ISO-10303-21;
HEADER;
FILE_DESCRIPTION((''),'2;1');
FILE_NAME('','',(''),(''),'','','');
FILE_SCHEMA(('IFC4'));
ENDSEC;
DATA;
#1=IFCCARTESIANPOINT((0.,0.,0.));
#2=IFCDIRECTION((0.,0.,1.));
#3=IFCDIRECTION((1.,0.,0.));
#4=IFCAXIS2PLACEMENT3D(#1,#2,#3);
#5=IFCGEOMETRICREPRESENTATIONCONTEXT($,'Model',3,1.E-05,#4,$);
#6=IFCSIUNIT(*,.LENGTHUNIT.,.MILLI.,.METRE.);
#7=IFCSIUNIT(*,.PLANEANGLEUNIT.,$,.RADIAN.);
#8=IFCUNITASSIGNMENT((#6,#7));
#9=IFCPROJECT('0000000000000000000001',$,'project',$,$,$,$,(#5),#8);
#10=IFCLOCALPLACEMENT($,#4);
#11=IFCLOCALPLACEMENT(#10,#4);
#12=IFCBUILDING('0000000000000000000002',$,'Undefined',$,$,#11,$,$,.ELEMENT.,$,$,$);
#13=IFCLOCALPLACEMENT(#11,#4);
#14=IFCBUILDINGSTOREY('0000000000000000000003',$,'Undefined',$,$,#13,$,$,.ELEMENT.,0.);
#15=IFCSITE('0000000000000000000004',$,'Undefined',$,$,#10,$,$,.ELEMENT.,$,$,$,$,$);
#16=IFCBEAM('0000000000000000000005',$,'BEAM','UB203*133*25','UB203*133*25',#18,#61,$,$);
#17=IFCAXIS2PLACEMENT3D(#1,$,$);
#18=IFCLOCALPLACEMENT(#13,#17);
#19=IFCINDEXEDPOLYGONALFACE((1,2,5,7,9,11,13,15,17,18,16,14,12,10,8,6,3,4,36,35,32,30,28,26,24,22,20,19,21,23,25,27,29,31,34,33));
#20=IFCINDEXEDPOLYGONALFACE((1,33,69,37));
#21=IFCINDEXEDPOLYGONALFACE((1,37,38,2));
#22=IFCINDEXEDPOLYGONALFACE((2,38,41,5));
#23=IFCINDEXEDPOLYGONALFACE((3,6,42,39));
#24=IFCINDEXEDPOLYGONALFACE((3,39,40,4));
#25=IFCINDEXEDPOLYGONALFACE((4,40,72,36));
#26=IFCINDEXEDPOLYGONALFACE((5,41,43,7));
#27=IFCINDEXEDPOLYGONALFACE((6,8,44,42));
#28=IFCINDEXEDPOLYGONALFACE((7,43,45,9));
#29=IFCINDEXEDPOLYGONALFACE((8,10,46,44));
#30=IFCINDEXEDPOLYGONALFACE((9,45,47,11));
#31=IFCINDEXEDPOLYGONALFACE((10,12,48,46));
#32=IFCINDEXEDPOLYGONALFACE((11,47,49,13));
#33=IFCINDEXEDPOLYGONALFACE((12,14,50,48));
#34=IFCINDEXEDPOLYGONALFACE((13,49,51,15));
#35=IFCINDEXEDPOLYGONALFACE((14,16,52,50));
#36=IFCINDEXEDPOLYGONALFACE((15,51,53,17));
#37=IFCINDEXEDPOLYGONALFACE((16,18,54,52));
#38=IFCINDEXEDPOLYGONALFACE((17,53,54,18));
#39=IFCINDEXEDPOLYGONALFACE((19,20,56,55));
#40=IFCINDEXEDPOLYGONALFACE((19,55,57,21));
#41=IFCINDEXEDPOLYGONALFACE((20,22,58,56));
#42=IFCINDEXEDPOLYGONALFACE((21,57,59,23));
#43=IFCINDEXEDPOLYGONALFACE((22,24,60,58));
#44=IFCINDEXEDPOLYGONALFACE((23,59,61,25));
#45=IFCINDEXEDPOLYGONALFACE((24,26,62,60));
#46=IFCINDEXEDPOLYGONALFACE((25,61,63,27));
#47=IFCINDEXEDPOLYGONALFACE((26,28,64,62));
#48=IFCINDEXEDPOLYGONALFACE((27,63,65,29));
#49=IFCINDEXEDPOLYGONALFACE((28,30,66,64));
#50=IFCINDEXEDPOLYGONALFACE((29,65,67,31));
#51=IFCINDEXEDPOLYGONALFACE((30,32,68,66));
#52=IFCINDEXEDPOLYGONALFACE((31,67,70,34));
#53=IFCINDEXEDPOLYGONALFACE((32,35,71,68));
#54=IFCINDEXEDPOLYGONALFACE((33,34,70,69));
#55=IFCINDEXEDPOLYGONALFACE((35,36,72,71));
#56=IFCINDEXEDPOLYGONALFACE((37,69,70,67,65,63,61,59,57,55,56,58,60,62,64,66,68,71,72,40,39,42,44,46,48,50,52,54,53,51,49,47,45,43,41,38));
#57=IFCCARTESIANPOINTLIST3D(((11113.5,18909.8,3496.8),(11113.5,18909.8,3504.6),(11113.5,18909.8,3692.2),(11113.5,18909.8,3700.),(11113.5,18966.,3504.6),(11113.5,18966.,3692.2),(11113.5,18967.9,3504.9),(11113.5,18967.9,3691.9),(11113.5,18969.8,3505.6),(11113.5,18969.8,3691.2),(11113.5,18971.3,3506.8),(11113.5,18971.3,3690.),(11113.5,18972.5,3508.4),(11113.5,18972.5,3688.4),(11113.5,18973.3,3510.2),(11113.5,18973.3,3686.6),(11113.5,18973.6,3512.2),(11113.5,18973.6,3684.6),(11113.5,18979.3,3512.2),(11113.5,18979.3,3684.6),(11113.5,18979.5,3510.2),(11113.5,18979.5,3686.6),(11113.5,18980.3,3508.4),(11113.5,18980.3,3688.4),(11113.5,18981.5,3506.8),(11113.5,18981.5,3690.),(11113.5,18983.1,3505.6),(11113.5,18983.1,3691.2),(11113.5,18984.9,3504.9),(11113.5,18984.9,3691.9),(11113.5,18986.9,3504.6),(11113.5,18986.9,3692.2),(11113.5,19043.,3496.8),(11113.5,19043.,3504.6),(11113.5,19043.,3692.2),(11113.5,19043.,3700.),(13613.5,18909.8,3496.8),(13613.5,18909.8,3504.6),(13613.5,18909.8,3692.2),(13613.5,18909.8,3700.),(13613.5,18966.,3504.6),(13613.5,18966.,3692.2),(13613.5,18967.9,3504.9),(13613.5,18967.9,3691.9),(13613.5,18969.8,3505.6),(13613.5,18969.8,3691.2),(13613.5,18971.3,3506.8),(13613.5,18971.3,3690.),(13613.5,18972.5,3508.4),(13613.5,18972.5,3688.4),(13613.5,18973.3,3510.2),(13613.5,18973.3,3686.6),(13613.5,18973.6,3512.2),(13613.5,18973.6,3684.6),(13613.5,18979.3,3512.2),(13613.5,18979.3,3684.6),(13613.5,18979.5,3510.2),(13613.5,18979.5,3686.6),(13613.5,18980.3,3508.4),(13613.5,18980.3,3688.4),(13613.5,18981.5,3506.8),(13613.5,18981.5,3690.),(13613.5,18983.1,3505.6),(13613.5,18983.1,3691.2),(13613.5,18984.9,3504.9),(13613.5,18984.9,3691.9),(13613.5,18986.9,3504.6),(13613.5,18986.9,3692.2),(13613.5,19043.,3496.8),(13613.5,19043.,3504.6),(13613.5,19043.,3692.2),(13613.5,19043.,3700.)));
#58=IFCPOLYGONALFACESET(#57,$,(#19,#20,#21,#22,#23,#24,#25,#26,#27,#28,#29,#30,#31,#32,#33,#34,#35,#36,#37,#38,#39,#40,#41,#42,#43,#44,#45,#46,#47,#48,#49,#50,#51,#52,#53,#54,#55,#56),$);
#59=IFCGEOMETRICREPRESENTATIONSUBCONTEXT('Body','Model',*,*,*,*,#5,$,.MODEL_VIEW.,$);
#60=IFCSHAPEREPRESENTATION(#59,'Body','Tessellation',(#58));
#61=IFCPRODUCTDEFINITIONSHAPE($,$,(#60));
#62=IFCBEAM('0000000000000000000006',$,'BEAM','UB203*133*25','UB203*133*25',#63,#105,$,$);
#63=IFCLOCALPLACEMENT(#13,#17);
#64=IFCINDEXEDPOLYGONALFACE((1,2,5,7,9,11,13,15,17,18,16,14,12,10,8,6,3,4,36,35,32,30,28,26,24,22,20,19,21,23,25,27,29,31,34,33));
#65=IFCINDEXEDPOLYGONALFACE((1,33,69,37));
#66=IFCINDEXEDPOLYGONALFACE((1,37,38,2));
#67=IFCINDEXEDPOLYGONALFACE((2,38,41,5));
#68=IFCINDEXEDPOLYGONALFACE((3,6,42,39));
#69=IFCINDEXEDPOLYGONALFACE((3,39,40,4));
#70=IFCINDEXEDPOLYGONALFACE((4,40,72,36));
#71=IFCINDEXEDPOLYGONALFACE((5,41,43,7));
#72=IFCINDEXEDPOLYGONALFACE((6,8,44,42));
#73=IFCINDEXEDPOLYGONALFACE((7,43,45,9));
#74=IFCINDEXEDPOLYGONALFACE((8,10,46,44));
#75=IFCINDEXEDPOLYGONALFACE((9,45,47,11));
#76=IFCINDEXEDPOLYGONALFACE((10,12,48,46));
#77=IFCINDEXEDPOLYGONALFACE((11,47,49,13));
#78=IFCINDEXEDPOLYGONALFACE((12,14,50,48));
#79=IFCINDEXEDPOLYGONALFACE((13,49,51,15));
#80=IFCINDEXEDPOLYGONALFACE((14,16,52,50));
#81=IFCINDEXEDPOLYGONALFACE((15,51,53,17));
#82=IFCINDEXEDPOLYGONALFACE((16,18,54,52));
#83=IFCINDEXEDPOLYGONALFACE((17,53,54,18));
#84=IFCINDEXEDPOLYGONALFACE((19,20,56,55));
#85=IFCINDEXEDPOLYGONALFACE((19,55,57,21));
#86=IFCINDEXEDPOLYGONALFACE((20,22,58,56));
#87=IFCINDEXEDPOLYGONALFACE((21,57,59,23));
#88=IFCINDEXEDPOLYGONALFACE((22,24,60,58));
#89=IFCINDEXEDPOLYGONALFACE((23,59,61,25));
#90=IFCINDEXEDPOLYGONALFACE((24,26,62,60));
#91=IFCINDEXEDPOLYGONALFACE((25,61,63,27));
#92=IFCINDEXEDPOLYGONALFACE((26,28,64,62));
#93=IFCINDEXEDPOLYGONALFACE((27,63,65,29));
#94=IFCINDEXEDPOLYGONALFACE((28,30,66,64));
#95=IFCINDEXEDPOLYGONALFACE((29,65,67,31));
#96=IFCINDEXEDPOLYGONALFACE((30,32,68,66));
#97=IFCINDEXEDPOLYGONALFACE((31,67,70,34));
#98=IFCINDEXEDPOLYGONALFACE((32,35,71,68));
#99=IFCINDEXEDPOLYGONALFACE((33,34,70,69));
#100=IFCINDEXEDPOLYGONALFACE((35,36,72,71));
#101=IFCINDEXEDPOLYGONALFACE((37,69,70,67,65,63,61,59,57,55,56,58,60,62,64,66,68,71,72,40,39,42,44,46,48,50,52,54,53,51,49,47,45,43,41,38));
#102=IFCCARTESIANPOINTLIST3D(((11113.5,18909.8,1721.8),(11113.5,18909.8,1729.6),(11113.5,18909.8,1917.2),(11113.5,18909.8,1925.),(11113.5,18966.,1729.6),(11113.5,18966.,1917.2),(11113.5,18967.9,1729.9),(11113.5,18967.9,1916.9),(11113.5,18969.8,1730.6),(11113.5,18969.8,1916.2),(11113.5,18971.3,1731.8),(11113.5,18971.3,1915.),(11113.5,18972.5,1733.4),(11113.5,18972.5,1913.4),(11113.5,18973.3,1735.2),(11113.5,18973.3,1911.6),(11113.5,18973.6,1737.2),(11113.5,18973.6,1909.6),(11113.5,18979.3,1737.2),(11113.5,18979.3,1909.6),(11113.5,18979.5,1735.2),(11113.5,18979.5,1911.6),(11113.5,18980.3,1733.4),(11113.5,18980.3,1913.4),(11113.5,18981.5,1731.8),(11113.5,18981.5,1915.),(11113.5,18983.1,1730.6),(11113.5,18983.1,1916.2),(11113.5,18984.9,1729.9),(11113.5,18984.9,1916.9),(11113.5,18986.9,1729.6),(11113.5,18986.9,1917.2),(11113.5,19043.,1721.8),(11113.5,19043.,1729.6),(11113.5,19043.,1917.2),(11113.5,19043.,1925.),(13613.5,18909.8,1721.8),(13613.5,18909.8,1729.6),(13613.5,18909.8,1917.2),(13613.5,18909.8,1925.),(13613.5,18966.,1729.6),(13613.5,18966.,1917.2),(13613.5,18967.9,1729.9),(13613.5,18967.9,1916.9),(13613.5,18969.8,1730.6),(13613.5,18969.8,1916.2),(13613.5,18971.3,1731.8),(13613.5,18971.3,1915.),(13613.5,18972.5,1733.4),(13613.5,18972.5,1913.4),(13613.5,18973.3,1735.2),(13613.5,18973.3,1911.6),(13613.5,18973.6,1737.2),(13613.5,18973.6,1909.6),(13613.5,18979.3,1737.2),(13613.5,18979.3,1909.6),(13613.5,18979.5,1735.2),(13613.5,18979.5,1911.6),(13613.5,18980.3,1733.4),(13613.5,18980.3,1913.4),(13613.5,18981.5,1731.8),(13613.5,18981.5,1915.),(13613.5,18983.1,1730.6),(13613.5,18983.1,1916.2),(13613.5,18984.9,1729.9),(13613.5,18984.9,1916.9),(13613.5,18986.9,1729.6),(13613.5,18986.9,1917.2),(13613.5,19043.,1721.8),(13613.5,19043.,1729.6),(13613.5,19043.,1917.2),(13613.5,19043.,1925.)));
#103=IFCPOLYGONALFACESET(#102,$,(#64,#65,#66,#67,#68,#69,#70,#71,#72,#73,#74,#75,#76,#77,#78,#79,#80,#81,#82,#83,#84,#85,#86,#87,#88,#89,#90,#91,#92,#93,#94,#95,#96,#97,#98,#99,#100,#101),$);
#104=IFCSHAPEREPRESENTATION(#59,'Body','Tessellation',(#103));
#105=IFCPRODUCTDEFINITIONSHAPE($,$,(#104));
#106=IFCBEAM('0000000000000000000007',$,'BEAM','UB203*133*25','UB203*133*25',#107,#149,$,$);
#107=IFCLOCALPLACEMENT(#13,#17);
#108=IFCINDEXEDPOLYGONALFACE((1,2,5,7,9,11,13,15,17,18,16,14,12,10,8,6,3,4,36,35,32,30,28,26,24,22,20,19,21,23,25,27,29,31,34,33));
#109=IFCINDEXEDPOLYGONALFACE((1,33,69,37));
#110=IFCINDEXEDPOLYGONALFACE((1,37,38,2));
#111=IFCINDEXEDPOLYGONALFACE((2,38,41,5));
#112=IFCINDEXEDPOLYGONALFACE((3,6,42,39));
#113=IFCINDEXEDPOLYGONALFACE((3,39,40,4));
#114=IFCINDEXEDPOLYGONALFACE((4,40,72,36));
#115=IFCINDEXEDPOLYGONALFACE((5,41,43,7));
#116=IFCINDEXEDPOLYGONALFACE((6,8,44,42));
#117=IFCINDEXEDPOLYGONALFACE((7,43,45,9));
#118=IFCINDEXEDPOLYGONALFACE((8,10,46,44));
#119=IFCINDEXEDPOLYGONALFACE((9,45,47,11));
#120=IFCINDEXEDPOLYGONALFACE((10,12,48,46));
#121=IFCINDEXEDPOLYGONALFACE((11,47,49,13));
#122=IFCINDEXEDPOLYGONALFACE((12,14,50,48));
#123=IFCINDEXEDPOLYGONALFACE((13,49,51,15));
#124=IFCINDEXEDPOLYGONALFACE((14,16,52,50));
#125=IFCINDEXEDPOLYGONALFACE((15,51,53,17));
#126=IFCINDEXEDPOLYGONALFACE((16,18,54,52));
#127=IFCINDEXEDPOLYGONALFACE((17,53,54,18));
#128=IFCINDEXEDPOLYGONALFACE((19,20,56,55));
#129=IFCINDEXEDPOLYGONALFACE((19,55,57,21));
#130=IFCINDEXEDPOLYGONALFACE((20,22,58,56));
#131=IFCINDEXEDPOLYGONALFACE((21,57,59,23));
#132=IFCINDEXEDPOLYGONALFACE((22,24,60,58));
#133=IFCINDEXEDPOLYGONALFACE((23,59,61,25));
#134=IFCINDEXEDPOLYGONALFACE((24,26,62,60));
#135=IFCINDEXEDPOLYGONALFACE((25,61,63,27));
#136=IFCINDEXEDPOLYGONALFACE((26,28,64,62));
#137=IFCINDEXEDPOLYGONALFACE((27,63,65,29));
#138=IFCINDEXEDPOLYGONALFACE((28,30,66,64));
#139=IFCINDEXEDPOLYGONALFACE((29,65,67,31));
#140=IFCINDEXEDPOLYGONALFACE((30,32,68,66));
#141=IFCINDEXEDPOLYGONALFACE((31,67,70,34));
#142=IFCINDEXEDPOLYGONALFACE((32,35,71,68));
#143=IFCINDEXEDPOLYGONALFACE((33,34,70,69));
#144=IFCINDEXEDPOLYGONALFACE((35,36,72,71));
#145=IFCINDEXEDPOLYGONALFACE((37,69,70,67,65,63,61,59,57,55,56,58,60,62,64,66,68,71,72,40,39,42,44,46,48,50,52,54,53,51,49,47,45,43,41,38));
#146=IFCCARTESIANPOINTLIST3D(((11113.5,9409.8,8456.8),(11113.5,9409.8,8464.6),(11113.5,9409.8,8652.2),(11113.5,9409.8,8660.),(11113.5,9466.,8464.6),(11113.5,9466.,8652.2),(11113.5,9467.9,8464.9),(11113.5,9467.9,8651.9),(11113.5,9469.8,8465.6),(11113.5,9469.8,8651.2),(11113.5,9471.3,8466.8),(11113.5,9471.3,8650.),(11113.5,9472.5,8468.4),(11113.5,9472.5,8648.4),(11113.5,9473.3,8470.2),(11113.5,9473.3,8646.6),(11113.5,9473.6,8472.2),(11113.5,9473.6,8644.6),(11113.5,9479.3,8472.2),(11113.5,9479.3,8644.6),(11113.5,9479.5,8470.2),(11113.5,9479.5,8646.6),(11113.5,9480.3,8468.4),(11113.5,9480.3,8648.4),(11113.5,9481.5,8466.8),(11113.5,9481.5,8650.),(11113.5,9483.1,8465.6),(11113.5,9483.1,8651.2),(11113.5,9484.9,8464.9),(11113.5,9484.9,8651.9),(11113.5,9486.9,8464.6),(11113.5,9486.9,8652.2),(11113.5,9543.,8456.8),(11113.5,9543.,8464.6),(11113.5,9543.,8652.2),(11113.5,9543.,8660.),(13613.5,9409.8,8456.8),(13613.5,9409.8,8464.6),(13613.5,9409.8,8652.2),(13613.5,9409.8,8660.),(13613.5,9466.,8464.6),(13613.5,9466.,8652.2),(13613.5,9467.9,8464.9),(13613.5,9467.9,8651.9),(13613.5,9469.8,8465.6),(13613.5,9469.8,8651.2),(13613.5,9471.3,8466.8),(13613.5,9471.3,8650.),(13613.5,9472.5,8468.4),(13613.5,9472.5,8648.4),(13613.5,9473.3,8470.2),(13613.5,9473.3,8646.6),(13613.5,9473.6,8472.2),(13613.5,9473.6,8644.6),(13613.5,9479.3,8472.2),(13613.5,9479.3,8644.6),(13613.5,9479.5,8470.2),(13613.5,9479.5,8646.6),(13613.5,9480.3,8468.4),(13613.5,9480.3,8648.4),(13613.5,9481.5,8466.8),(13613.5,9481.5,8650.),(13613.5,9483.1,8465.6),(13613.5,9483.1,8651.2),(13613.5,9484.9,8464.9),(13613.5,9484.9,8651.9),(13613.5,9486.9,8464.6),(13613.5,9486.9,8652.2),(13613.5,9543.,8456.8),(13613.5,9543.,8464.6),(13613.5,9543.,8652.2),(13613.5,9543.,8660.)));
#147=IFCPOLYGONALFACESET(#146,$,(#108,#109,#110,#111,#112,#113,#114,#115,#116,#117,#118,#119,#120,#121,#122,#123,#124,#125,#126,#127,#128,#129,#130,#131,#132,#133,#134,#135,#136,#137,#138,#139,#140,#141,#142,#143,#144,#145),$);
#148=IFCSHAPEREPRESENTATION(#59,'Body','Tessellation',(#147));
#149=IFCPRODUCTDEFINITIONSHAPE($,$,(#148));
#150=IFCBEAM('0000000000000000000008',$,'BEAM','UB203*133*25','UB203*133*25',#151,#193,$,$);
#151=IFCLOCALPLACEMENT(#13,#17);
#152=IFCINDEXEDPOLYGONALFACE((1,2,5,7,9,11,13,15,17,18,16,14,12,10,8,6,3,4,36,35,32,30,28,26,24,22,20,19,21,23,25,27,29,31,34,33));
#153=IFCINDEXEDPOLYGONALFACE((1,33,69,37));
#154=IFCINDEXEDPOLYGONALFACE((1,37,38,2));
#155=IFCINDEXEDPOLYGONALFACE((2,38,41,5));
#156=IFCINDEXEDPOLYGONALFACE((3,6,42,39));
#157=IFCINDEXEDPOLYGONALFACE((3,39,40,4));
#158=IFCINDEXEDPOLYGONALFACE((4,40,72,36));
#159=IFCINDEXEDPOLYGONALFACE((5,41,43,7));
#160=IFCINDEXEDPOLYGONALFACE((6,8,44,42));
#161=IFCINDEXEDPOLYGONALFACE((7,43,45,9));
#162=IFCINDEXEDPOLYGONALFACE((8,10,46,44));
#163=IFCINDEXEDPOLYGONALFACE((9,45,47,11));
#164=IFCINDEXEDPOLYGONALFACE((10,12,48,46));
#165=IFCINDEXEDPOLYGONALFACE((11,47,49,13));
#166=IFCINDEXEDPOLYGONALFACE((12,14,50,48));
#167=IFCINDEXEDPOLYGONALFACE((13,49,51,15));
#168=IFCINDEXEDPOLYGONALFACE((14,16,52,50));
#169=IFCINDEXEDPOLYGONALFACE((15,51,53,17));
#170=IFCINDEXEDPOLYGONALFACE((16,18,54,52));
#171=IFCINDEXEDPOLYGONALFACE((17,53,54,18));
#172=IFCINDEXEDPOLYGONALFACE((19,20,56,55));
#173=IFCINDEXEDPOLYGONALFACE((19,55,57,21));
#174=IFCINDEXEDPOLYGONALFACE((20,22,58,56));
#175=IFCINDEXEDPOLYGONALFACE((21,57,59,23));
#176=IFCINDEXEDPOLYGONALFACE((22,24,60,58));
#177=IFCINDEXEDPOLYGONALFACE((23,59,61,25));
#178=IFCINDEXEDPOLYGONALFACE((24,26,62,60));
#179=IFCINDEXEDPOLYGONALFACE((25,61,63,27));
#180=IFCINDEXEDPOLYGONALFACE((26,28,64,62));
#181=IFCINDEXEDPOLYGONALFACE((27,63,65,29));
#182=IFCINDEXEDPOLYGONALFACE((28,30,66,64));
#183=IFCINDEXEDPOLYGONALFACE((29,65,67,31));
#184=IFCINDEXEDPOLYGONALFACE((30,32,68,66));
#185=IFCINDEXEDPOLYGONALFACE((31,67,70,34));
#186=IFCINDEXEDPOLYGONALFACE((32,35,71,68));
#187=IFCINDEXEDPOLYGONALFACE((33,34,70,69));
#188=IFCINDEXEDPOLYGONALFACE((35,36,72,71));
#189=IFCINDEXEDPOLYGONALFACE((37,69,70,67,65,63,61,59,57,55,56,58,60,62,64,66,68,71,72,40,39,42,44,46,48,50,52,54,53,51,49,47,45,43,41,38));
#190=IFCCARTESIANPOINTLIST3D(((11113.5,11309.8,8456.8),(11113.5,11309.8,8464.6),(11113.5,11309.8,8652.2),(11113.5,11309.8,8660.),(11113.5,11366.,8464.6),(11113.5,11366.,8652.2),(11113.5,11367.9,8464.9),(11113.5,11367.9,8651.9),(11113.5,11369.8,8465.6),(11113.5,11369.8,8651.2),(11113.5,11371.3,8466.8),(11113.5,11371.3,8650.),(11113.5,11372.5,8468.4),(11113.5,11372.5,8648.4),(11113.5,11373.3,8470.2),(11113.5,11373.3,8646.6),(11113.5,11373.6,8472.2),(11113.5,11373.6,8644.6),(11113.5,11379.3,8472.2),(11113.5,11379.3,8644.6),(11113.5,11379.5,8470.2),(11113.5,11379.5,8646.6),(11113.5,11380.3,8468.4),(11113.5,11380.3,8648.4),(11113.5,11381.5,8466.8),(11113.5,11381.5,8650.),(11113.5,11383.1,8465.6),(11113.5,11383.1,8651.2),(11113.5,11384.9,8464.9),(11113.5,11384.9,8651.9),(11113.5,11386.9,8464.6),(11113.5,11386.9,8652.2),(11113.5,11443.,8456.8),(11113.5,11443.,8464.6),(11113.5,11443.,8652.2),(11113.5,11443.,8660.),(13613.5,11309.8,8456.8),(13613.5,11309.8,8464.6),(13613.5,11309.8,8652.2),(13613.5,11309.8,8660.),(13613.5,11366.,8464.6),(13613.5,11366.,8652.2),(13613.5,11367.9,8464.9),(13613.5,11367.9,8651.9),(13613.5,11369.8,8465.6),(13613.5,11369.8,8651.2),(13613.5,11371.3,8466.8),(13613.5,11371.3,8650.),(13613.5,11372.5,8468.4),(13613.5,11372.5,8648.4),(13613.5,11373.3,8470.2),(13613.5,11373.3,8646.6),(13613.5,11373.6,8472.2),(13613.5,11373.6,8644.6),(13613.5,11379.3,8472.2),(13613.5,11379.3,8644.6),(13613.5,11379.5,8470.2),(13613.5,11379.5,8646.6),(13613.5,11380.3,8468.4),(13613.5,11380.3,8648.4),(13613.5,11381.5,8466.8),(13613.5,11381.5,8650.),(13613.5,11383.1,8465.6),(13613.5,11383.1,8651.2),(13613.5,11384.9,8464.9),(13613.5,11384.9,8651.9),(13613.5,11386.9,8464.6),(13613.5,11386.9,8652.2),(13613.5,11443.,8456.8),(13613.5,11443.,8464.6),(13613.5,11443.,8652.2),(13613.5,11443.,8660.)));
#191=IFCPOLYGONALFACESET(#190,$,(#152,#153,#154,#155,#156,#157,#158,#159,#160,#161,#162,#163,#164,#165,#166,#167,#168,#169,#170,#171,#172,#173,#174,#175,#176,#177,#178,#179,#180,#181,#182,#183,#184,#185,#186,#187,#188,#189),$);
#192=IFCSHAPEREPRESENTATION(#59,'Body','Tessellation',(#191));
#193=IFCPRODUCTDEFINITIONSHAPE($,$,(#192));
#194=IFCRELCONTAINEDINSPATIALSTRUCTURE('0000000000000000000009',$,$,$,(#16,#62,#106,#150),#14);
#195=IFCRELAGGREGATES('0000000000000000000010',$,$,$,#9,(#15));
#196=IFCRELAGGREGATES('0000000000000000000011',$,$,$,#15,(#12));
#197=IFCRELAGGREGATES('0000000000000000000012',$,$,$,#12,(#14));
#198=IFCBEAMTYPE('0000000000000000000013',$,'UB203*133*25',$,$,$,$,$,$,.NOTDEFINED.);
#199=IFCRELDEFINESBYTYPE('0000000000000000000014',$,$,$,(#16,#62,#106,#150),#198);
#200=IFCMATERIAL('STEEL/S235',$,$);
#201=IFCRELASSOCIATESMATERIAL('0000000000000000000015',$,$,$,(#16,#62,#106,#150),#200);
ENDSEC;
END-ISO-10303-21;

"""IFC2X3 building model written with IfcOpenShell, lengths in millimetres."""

from ifc_helpers import new_model, si_unit, frame, origin_with_axes, origin_2d_with_axis, place, context, subcontext, project, spatial, i_section, extrude, material, type_object, element, save


model = new_model("IFC2X3")

# Units and contexts
model_context = context("Model", 3, precision=1e-05, world=origin_with_axes())
body_context = subcontext(model_context, "Body", "Model", "MODEL_VIEW")
ifc_project = project(units=[si_unit("LENGTHUNIT", "METRE", prefix="MILLI"), si_unit("PLANEANGLEUNIT", "RADIAN")], contexts=[model_context])

# Site, building, storey
site_placement = place(None, origin_with_axes())
site = spatial("IfcSite", under=ifc_project, at=site_placement, Name="Undefined", CompositionType="ELEMENT")
building_placement = place(site_placement, origin_with_axes())
building = spatial("IfcBuilding", under=site, at=building_placement, Name="Undefined", CompositionType="ELEMENT")
storey_placement = place(building_placement, origin_with_axes())
storey = spatial("IfcBuildingStorey", under=building, at=storey_placement, Name="Undefined", CompositionType="ELEMENT", Elevation=0.0)

# Shared definitions
ifc_material = material(Name="STEEL/S235")

# Beams
beam_type_1 = type_object("IfcBeamType", Name="UB203*133*25", PredefinedType="NOTDEFINED")
for number, where, z_axis, x_axis, name in (
    (1, (11113.5, 18976.4, 3598.4), (0.0, 0.0, 1.0), (1.0, 0.0, 0.0), "BEAM"),
    (2, (11113.5, 18976.4, 1823.4), (0.0, 0.0, 1.0), (1.0, 0.0, 0.0), "BEAM"),
    (3, (11113.5, 9476.4, 8558.4), (0.0, 0.0, 1.0), (1.0, 0.0, 0.0), "BEAM"),
    (4, (11113.5, 11376.4, 8558.4), (0.0, 0.0, 1.0), (1.0, 0.0, 0.0), "BEAM"),
):
    element("IfcBeam", number, at=place(storey_placement, frame(where, z_axis=z_axis, x_axis=x_axis)), inside=storey, type_object=beam_type_1, material=ifc_material, Name=name, Description="UB203*133*25", ObjectType="UB203*133*25", context=body_context, shape_type="SweptSolid", body=[
        extrude(i_section(OverallWidth=133.2, OverallDepth=203.2, WebThickness=5.7, FlangeThickness=7.8, FilletRadius=7.6, at=origin_2d_with_axis()), frame((2500.0, 0.0, 0.0), z_axis=(-1.0, 0.0, 0.0), x_axis=(0.0, -1.0, 0.0)), (0.0, 0.0, 1.0), 2500.0),
    ])

save(model, "model.ifc")
